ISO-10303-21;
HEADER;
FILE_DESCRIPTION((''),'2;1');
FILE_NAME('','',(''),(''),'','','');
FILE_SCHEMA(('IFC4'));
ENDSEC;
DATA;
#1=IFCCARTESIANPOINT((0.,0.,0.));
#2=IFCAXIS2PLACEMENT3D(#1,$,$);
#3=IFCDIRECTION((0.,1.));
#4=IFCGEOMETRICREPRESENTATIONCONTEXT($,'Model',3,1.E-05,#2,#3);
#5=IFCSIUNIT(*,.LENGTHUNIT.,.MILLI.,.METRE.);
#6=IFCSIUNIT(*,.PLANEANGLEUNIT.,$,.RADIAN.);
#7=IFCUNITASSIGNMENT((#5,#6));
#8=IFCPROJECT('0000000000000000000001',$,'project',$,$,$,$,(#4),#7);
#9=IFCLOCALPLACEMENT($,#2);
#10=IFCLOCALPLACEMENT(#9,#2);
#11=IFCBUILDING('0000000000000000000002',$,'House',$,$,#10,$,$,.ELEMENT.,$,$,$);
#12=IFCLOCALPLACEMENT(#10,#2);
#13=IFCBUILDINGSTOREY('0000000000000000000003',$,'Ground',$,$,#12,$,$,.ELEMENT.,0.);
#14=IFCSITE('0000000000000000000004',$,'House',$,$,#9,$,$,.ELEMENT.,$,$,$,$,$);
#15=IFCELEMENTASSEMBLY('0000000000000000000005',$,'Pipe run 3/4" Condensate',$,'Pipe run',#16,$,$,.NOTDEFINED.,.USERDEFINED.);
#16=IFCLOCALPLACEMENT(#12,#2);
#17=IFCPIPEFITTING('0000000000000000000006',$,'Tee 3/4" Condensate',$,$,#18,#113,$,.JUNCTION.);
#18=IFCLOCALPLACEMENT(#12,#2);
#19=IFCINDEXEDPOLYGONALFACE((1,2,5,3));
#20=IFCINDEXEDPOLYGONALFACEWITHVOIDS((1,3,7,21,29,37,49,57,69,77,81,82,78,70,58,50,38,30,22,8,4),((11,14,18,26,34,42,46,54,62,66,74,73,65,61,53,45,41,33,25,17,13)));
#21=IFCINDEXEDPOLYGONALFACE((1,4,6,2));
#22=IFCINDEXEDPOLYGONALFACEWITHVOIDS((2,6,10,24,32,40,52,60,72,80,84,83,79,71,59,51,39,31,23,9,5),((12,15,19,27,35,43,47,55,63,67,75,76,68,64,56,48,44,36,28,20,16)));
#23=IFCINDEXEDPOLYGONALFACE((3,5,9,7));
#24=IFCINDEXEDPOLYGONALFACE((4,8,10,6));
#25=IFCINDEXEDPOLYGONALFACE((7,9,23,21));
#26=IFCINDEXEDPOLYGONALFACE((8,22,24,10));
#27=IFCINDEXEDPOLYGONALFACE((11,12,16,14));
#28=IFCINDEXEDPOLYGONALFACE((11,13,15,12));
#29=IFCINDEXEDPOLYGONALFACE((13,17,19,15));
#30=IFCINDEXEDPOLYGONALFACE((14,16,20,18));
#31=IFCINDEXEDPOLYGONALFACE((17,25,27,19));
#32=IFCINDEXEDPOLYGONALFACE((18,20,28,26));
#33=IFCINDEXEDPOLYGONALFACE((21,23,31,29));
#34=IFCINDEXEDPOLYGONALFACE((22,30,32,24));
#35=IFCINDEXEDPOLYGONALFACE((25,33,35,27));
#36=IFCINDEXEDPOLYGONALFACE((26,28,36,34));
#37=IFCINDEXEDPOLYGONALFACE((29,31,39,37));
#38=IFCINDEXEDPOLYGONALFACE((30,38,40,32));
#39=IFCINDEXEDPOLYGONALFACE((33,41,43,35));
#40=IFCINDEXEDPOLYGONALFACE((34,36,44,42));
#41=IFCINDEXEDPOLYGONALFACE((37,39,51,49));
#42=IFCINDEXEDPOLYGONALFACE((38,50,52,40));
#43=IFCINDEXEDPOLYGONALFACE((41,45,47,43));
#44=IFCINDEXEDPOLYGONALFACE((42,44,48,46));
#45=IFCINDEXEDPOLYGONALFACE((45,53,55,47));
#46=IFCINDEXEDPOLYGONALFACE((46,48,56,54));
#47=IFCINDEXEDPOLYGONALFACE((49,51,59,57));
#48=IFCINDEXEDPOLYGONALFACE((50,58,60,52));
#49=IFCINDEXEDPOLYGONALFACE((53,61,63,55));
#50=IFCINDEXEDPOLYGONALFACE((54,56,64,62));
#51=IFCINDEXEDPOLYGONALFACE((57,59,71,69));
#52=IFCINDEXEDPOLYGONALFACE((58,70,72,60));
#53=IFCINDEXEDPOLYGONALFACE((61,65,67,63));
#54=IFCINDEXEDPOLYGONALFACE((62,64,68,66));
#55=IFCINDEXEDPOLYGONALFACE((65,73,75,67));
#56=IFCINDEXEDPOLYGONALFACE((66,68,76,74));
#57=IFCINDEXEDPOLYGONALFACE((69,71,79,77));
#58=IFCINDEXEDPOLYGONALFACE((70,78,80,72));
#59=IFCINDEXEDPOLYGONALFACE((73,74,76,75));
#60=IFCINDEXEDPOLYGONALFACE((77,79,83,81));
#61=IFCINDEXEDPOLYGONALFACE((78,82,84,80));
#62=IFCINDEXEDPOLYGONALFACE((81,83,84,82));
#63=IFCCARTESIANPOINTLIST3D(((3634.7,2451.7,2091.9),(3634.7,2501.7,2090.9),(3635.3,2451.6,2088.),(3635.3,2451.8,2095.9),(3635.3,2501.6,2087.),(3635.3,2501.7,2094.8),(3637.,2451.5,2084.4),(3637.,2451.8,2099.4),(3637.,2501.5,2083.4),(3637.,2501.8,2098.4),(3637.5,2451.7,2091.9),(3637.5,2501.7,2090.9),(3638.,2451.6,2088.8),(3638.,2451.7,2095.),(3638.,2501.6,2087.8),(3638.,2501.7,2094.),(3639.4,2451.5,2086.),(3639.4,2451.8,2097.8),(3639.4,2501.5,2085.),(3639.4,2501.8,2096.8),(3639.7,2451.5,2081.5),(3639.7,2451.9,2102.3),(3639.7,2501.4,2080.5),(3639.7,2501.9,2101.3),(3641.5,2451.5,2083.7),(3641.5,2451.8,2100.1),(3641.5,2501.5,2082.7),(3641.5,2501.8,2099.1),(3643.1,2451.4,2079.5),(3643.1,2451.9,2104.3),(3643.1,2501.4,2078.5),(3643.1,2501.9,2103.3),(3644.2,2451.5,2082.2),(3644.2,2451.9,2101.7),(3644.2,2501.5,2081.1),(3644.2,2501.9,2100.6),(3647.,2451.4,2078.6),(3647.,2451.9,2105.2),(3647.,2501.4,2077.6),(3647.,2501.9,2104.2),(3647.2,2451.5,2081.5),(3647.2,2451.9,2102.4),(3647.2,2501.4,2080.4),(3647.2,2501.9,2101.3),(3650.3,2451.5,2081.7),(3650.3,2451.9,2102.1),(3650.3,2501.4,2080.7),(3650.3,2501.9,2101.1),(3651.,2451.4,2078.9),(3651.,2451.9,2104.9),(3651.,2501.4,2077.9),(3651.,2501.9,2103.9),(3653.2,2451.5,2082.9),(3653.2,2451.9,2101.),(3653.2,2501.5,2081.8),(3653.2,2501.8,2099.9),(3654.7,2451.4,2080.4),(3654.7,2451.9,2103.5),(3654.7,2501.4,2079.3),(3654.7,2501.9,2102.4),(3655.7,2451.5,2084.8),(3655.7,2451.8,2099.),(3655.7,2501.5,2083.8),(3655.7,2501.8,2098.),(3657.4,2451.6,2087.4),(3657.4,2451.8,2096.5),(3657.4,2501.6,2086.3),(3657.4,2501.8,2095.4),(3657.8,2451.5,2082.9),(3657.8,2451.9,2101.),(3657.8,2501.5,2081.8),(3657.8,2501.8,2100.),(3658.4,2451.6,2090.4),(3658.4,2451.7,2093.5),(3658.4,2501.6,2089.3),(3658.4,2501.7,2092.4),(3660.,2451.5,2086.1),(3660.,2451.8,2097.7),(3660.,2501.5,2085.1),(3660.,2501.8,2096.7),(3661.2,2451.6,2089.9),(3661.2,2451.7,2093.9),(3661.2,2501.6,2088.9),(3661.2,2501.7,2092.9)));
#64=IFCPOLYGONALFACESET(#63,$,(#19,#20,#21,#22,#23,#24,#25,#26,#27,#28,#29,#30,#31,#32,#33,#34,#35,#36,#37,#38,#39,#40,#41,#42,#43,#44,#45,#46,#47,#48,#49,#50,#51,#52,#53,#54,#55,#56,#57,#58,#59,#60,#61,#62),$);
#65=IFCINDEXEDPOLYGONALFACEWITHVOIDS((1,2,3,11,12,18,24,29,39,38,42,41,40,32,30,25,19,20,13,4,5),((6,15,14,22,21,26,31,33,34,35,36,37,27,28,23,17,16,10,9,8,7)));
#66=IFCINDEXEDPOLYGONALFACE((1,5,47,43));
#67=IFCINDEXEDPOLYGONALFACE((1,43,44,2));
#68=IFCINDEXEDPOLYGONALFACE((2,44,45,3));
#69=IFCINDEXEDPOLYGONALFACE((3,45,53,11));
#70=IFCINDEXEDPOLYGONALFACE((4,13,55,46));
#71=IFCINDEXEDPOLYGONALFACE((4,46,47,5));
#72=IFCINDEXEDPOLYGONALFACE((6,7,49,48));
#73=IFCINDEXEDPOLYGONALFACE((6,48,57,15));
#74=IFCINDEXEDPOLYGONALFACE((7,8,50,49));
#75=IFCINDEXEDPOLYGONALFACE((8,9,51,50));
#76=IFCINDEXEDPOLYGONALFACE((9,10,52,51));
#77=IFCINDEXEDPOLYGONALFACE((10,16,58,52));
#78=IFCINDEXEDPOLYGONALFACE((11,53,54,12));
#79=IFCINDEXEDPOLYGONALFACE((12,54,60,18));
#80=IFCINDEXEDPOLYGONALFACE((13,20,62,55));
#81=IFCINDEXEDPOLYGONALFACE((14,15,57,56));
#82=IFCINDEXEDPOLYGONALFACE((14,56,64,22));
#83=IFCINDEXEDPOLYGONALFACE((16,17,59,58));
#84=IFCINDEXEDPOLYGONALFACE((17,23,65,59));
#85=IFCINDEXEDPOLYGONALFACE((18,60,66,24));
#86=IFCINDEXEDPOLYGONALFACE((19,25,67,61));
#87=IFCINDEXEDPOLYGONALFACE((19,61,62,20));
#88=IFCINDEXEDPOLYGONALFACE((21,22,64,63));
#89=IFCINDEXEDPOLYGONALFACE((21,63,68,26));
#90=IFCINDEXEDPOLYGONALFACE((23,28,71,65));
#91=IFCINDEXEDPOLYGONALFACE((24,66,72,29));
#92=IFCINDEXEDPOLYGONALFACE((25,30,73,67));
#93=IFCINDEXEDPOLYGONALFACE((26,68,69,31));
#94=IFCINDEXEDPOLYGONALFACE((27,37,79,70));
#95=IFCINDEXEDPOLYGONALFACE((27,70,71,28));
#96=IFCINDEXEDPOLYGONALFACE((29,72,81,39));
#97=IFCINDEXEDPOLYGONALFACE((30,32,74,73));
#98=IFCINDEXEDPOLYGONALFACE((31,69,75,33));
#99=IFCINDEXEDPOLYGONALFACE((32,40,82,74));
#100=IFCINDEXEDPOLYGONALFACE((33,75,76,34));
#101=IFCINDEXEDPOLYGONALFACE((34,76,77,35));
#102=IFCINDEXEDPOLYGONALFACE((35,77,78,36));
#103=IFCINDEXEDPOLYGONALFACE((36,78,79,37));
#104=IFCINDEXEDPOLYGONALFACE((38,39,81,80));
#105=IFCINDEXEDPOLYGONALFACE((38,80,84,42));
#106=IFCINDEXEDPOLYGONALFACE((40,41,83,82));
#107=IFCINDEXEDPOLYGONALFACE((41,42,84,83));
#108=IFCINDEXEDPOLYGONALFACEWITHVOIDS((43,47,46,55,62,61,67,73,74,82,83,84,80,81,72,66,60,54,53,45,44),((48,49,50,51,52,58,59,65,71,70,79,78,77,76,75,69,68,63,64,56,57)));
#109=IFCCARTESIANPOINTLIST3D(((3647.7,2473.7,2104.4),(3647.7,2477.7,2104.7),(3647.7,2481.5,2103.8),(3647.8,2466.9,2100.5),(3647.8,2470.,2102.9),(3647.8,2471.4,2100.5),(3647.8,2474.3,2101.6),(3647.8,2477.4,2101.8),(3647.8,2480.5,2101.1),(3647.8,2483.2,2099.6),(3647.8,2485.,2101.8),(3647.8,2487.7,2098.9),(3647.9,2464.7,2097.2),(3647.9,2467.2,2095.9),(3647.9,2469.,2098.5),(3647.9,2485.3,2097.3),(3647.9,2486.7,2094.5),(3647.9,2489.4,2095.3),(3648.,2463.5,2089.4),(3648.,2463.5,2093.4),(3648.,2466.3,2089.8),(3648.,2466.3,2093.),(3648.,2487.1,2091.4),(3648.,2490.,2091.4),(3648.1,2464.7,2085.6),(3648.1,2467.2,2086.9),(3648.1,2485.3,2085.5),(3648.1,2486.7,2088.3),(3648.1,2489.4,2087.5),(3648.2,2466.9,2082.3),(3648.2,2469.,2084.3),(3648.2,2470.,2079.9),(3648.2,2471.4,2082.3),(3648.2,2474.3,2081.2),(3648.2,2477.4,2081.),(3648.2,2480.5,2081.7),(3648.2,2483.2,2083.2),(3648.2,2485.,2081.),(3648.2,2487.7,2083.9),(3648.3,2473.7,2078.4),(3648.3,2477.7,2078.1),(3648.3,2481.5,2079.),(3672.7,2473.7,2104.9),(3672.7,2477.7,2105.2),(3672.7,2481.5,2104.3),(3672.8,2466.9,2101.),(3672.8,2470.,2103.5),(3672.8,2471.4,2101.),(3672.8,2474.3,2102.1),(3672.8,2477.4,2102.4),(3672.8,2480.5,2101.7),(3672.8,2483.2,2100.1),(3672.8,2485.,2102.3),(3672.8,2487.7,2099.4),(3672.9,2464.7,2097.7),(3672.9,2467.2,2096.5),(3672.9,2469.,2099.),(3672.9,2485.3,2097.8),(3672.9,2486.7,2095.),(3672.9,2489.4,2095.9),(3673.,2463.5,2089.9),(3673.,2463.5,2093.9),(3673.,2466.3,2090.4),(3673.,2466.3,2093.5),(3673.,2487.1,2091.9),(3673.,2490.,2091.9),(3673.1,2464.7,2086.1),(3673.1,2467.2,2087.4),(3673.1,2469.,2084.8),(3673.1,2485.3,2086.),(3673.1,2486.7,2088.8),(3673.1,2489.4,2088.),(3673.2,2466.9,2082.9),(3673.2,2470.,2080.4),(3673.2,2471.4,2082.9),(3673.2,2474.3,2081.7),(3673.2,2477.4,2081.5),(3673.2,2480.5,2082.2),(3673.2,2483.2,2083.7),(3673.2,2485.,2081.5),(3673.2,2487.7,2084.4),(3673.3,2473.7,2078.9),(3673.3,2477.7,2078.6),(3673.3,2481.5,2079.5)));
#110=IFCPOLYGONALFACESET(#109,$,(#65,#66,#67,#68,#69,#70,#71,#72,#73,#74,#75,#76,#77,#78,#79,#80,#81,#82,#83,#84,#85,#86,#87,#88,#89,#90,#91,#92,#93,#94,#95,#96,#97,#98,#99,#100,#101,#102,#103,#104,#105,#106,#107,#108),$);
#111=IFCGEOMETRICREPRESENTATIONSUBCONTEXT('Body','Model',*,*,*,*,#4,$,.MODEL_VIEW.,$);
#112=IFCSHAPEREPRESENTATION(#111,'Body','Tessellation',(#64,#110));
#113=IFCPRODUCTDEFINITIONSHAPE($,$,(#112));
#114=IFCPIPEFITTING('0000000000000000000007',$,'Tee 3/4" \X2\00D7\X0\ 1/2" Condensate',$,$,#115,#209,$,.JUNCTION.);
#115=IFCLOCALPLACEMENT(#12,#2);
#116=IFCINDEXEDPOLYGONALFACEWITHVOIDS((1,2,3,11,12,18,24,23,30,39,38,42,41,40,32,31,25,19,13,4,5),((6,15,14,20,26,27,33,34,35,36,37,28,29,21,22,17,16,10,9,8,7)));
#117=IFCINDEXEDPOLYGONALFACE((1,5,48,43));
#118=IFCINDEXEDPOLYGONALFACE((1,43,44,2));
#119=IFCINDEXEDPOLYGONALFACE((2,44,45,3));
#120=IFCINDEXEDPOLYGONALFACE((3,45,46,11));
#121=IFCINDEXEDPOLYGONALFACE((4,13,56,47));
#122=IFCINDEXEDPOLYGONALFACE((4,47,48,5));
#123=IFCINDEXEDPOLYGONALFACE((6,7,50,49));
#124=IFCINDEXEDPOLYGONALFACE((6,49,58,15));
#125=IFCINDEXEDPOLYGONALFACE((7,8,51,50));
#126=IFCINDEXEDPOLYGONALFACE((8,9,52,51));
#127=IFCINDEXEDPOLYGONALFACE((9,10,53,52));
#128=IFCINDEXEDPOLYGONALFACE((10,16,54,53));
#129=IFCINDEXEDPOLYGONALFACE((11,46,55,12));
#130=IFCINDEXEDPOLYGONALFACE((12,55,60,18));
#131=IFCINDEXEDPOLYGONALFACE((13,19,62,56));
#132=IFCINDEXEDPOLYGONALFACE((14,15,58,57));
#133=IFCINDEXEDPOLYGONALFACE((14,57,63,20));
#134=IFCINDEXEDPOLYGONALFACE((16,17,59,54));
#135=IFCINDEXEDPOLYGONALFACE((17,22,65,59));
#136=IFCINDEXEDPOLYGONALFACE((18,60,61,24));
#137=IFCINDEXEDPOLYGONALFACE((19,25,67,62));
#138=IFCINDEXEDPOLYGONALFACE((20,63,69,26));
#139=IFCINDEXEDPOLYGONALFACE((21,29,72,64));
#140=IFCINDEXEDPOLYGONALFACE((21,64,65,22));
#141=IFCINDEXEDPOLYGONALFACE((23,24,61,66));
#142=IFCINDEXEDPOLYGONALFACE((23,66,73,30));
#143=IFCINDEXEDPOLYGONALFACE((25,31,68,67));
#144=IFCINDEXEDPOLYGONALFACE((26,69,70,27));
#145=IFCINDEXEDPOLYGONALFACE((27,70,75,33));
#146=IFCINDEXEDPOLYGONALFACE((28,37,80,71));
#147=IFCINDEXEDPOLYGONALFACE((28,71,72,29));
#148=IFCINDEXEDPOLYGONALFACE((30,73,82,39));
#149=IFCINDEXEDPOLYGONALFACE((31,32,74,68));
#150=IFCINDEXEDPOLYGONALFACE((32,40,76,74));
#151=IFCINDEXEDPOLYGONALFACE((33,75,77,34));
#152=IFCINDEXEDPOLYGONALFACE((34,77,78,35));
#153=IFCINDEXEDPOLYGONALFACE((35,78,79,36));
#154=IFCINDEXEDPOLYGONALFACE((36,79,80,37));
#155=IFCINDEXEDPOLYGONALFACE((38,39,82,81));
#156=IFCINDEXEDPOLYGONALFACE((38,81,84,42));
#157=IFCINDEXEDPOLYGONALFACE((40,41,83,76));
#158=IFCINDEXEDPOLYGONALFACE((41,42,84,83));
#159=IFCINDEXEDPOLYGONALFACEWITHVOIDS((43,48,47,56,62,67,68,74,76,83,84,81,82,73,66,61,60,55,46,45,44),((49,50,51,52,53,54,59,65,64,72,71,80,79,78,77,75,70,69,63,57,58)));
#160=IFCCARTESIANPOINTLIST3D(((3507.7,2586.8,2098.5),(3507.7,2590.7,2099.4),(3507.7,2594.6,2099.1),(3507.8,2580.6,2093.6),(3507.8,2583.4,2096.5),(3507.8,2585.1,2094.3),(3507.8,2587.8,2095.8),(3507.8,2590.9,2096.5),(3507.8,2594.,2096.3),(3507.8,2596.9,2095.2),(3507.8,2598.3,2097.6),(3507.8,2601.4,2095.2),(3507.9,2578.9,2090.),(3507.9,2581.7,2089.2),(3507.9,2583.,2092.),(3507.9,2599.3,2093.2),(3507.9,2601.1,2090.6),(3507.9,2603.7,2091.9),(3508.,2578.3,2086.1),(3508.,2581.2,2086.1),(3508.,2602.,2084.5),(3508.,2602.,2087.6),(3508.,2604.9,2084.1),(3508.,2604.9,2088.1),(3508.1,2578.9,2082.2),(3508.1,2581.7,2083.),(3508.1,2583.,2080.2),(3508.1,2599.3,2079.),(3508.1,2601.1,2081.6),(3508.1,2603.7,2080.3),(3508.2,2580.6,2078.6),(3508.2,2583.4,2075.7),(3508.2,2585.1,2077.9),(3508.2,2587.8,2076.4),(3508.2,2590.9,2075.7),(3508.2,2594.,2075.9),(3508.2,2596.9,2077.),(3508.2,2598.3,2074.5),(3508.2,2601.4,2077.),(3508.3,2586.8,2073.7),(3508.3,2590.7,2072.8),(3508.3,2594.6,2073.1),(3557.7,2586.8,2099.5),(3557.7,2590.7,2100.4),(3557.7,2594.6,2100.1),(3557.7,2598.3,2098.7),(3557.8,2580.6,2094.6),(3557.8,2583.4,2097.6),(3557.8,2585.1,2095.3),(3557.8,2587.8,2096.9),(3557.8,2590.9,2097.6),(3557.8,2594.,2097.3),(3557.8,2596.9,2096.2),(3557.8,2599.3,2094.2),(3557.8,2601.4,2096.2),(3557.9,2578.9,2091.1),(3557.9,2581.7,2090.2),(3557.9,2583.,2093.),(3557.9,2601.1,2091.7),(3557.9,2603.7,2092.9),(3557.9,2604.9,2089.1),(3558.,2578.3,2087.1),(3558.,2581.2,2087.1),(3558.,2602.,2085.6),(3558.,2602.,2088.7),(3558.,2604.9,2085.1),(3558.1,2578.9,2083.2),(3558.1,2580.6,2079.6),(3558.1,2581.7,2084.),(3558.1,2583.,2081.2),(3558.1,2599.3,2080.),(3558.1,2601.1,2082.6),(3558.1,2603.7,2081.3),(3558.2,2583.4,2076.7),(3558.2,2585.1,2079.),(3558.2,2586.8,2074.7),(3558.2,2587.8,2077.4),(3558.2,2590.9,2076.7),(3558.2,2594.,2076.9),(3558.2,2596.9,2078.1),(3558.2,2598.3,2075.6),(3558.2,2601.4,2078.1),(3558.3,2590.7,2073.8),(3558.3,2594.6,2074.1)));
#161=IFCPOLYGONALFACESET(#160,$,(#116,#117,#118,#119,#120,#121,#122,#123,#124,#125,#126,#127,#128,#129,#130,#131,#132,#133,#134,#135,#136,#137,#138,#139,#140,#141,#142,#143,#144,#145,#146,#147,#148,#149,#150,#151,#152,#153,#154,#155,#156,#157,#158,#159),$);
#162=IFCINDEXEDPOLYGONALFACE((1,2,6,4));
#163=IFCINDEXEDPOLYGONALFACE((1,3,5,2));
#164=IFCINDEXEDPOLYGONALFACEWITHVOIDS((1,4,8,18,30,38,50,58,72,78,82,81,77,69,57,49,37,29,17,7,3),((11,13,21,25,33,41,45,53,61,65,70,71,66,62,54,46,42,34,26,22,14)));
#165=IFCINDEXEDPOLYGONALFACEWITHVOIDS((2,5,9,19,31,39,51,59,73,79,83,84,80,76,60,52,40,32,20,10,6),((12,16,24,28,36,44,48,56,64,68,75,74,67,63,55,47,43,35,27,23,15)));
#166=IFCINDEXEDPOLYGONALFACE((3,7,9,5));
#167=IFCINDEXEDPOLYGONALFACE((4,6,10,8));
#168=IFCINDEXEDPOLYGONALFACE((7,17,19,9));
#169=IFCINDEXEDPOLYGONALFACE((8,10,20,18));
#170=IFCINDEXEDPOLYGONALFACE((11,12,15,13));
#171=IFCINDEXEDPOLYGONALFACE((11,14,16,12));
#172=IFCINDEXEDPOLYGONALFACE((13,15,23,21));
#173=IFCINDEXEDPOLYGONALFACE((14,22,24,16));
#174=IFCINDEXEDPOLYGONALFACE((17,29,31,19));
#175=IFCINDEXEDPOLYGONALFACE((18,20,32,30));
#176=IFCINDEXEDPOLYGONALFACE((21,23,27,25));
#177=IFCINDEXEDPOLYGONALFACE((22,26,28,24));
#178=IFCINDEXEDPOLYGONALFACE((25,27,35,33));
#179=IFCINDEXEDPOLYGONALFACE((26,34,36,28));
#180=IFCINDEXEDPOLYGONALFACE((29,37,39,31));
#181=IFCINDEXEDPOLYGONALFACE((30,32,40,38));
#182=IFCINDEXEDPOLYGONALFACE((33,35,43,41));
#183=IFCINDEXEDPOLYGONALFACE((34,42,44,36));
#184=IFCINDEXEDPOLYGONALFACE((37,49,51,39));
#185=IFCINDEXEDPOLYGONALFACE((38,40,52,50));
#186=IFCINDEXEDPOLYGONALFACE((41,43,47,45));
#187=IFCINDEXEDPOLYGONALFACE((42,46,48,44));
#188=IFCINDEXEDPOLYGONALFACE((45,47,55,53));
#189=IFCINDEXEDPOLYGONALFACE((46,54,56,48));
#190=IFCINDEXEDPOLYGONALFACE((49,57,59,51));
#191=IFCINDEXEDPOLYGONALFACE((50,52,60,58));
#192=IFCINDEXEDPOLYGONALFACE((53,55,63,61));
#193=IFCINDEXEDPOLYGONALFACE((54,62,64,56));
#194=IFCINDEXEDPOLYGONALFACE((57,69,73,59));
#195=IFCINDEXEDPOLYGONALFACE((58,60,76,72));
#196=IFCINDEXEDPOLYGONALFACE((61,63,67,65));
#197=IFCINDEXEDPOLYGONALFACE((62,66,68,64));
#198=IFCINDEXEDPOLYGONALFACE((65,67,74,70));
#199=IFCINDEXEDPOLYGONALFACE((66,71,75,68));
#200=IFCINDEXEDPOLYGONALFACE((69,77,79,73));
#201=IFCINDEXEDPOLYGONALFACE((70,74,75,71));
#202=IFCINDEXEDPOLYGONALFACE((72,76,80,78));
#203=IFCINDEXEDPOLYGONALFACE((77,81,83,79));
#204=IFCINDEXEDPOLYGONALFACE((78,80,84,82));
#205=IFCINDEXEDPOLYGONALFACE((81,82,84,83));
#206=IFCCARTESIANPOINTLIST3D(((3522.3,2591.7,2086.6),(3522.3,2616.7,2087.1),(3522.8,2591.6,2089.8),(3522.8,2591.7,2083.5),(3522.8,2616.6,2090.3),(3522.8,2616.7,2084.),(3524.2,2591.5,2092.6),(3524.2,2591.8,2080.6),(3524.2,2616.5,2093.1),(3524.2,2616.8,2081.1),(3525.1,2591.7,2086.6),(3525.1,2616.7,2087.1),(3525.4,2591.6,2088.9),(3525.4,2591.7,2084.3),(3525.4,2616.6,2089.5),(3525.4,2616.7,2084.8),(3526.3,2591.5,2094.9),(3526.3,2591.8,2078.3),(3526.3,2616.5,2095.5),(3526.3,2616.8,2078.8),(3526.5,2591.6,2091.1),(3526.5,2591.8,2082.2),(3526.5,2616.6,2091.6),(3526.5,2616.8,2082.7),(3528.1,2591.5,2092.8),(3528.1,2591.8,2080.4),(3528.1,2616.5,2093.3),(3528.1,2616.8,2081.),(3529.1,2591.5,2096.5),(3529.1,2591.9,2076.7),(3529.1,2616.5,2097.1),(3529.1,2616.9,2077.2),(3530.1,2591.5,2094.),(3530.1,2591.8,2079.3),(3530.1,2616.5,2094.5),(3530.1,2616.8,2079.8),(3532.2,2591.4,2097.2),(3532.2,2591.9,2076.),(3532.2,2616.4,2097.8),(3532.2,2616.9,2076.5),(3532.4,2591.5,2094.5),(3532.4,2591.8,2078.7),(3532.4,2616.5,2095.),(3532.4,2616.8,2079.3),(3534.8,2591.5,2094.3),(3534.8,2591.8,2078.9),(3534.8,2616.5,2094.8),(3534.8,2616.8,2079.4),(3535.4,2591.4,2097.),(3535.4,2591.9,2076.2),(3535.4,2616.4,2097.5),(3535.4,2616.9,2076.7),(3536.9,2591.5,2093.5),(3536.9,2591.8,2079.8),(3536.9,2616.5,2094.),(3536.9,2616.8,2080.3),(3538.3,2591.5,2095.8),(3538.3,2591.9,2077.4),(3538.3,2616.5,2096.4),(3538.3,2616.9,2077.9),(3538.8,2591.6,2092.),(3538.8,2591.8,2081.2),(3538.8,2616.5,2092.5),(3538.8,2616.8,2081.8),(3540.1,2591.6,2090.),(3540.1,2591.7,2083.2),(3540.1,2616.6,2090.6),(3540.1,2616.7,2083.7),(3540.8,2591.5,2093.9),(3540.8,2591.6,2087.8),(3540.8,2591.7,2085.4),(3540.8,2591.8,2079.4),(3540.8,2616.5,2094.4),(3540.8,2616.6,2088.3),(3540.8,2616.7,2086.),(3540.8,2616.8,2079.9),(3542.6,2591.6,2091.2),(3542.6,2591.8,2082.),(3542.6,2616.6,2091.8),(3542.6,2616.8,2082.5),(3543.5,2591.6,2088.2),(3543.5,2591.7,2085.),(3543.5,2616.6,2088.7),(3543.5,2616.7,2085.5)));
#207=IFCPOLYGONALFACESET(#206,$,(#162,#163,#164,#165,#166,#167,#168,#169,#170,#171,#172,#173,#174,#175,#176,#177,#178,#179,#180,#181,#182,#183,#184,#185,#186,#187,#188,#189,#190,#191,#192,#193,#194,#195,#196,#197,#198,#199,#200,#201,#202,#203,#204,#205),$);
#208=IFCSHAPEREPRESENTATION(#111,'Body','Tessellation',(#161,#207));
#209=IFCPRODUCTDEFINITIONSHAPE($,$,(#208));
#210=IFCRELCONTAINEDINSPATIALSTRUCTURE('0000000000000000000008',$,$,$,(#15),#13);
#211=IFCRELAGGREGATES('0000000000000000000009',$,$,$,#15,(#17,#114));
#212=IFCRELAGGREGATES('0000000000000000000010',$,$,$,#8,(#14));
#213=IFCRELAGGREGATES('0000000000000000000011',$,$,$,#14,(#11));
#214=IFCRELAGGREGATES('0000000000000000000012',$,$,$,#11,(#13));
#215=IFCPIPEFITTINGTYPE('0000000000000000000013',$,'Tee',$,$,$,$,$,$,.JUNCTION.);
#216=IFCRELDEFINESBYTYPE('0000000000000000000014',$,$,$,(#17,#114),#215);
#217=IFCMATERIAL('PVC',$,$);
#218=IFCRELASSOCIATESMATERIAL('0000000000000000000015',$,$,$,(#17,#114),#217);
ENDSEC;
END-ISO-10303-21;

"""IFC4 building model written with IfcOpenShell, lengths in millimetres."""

from ifc_helpers import new_model, si_unit, direction, frame, origin, origin_with_axes, origin_2d, place, context, subcontext, project, spatial, hollow_circle, extrude, material, type_object, element, aggregate, save


model = new_model("IFC4")

# Units and contexts
model_context = context("Model", 3, precision=1e-05, world=origin(), true_north=direction((0.0, 1.0)))
body_context = subcontext(model_context, "Body", "Model", "MODEL_VIEW")
ifc_project = project(units=[si_unit("LENGTHUNIT", "METRE", prefix="MILLI"), si_unit("PLANEANGLEUNIT", "RADIAN")], contexts=[model_context])

# Site, building, storey
site_placement = place(None, origin())
site = spatial("IfcSite", under=ifc_project, at=site_placement, Name="House", CompositionType="ELEMENT")
building_placement = place(site_placement, origin())
building = spatial("IfcBuilding", under=site, at=building_placement, Name="House", CompositionType="ELEMENT")
storey_placement = place(building_placement, origin())
storey = spatial("IfcBuildingStorey", under=building, at=storey_placement, Name="Ground", CompositionType="ELEMENT", Elevation=0.0)

# Element assembly
ifc_material_1 = material(Name="PVC")
assembly_1_placement = place(storey_placement, origin_with_axes())
assembly_1 = element("IfcElementAssembly", 1, at=assembly_1_placement, inside=storey, Name="Pipe run 3/4\" Condensate", ObjectType="Pipe run", AssemblyPlace="NOTDEFINED", PredefinedType="USERDEFINED")

# Pipe fittings
pipe_fitting_type_1 = type_object("IfcPipeFittingType", Name="Tee", PredefinedType="JUNCTION")
pipe_fitting_1_placement = place(storey_placement, origin_with_axes())
pipe_fitting_1 = element("IfcPipeFitting", 2, at=pipe_fitting_1_placement, type_object=pipe_fitting_type_1, material=ifc_material_1, Name="Tee 3/4\" Condensate", PredefinedType="JUNCTION", context=body_context, shape_type="SweptSolid", body=[
    extrude(hollow_circle(Radius=13.3, WallThickness=2.9, at=origin_2d()), frame((3648.0, 2451.7, 2091.9), z_axis=(0.0, 0.999783, -0.020829), x_axis=(-1.0, 0.0, 0.0)), (0.0, 0.0, 1.0), 50.0),
    extrude(hollow_circle(Radius=13.3, WallThickness=2.9, at=origin_2d()), frame((3648.0, 2476.7, 2091.4), z_axis=(0.999783, 0.0, 0.020829), x_axis=(0.0, 1.0, 0.0)), (0.0, 0.0, 1.0), 25.0),
])
pipe_fitting_2_placement = place(storey_placement, origin_with_axes())
pipe_fitting_2 = element("IfcPipeFitting", 3, at=pipe_fitting_2_placement, type_object=pipe_fitting_type_1, material=ifc_material_1, Name="Tee 3/4\" × 1/2\" Condensate", PredefinedType="JUNCTION", context=body_context, shape_type="SweptSolid", body=[
    extrude(hollow_circle(Radius=13.3, WallThickness=2.9, at=origin_2d()), frame((3558.0, 2591.7, 2087.1), z_axis=(-0.999783, 0.0, -0.020829), x_axis=(0.0, -1.0, 0.0)), (0.0, 0.0, 1.0), 50.0),
    extrude(hollow_circle(Radius=10.7, WallThickness=2.8, at=origin_2d()), frame((3533.0, 2591.7, 2086.6), z_axis=(0.0, 0.999783, 0.020829), x_axis=(-1.0, 0.0, 0.0)), (0.0, 0.0, 1.0), 25.0),
])

aggregate(assembly_1, [pipe_fitting_1, pipe_fitting_2])

save(model, "model.ifc")
